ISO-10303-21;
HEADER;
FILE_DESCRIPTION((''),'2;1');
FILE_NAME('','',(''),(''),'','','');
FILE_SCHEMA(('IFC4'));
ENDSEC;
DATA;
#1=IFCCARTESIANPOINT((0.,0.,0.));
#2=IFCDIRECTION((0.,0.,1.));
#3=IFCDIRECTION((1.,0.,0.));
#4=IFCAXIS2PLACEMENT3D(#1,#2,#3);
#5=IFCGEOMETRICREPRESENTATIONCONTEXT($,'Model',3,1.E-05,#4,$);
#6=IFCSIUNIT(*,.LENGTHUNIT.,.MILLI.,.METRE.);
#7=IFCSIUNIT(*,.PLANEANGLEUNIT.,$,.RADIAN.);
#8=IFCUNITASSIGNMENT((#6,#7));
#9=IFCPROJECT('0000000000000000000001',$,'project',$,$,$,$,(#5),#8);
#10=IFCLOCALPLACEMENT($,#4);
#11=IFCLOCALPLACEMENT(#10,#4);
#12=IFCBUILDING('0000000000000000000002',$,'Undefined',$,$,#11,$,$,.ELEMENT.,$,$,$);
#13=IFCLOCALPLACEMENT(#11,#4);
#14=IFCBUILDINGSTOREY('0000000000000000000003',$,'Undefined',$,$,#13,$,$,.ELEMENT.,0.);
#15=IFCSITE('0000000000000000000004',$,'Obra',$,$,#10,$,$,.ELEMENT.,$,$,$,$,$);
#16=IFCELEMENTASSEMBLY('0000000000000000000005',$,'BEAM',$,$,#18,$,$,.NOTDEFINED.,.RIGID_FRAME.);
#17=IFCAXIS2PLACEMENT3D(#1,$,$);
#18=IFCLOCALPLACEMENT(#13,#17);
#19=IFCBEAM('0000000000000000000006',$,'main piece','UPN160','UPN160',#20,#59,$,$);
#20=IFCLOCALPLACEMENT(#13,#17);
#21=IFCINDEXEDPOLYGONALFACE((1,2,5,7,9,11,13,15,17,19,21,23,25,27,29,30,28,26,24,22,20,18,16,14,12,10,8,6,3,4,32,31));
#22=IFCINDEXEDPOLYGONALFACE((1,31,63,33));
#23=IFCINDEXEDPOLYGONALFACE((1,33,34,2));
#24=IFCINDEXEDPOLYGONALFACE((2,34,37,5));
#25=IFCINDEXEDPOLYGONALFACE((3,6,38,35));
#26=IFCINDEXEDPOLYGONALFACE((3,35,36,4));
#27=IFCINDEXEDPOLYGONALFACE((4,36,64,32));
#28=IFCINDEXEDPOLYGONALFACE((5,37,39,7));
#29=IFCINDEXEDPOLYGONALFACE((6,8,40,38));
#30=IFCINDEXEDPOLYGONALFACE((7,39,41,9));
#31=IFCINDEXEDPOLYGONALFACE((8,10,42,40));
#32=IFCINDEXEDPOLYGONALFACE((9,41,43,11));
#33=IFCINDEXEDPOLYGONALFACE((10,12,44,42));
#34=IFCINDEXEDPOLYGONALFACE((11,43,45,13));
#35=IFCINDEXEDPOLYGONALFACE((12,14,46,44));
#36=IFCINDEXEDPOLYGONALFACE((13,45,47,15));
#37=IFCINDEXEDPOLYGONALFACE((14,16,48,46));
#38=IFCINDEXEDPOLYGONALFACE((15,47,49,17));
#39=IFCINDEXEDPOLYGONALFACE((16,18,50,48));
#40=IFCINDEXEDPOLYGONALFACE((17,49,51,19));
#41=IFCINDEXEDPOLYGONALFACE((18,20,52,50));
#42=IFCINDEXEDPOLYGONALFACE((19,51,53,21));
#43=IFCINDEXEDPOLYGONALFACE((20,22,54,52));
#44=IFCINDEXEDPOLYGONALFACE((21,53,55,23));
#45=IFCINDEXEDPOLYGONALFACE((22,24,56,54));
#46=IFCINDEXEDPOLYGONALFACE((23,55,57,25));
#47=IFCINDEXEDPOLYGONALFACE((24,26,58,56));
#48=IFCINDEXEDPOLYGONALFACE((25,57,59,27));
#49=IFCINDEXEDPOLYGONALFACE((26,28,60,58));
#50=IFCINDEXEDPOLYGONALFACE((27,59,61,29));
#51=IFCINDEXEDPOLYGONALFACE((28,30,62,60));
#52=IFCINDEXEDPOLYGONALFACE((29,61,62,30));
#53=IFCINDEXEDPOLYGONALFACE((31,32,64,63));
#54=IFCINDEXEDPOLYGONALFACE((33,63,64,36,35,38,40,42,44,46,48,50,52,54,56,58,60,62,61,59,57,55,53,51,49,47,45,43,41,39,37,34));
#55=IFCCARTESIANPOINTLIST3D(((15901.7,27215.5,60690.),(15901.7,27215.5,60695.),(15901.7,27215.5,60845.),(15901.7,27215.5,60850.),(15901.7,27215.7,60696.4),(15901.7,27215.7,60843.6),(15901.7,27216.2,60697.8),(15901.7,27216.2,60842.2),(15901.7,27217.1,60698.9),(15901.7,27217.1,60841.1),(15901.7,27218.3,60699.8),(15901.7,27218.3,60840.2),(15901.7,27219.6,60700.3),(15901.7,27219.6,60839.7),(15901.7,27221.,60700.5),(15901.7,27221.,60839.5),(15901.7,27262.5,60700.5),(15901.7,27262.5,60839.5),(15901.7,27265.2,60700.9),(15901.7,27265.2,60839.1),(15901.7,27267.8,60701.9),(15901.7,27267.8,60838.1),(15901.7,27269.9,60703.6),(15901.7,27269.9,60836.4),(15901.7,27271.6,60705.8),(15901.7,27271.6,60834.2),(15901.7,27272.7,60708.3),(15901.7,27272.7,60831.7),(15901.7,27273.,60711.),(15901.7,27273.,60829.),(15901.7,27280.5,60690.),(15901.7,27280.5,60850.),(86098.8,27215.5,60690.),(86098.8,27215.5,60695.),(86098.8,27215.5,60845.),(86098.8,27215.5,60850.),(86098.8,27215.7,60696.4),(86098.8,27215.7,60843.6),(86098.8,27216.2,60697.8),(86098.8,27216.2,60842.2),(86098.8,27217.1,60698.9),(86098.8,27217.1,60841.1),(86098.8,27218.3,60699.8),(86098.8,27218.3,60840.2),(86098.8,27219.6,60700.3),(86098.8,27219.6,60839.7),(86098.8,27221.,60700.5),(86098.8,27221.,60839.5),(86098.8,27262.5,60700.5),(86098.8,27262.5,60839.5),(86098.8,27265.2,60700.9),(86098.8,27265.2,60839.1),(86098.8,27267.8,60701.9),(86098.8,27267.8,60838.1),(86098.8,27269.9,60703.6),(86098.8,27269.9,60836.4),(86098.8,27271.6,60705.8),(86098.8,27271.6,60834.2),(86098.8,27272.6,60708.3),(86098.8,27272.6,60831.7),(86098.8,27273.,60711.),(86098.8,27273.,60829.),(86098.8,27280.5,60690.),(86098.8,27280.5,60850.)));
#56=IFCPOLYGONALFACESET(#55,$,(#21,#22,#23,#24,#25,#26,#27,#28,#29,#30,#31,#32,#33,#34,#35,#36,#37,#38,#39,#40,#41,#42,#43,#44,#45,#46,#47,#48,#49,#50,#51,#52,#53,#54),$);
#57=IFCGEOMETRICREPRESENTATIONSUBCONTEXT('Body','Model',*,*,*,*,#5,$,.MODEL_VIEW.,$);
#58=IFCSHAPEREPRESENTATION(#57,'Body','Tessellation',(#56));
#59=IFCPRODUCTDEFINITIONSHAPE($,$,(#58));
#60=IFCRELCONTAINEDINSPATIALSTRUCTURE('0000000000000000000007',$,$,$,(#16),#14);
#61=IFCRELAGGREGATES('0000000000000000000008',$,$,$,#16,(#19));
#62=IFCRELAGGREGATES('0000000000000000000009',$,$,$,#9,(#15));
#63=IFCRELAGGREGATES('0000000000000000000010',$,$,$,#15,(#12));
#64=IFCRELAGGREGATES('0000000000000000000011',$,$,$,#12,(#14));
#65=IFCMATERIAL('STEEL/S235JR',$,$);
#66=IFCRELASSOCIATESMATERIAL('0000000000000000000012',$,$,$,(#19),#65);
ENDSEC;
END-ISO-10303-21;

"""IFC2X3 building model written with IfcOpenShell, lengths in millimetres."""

from ifc_helpers import new_model, si_unit, frame, origin_with_axes, origin_2d_with_axis, place, context, subcontext, project, spatial, u_section, extrude, material, element, aggregate, save


model = new_model("IFC2X3")

# Units and contexts
model_context = context("Model", 3, precision=1e-05, world=origin_with_axes())
body_context = subcontext(model_context, "Body", "Model", "MODEL_VIEW")
ifc_project = project(units=[si_unit("LENGTHUNIT", "METRE", prefix="MILLI"), si_unit("PLANEANGLEUNIT", "RADIAN")], contexts=[model_context])

# Site, building, storey
site_placement = place(None, origin_with_axes())
site = spatial("IfcSite", under=ifc_project, at=site_placement, Name="Obra", CompositionType="ELEMENT")
building_placement = place(site_placement, origin_with_axes())
building = spatial("IfcBuilding", under=site, at=building_placement, Name="Undefined", CompositionType="ELEMENT")
storey_placement = place(building_placement, origin_with_axes())
storey = spatial("IfcBuildingStorey", under=building, at=storey_placement, Name="Undefined", CompositionType="ELEMENT", Elevation=0.0)

# Element assembly, beam
ifc_material_1 = material(Name="STEEL/S235JR")
assembly_1_placement = place(storey_placement, origin_with_axes())
assembly_1 = element("IfcElementAssembly", 1, at=assembly_1_placement, inside=storey, Name="BEAM", AssemblyPlace="NOTDEFINED", PredefinedType="RIGID_FRAME")
beam_1_placement = place(assembly_1_placement, frame((15901.7, 27248.0, 60770.0), z_axis=(0.0, 0.0, 1.0), x_axis=(1.0, 0.0, 0.0)))
beam_1 = element("IfcBeam", 2, at=beam_1_placement, material=ifc_material_1, Name="main piece", Description="UPN160", ObjectType="UPN160", context=body_context, shape_type="SweptSolid", body=[
    extrude(u_section(Depth=160.0, FlangeWidth=65.0, WebThickness=7.5, FlangeThickness=10.5, FilletRadius=10.5, EdgeRadius=5.5, at=origin_2d_with_axis()), frame((70197.1, 0.0, 0.0), z_axis=(-1.0, 0.0, 0.0), x_axis=(0.0, -1.0, 0.0)), (0.0, 0.0, 1.0), 70197.1),
])
aggregate(assembly_1, [beam_1])

save(model, "model.ifc")
